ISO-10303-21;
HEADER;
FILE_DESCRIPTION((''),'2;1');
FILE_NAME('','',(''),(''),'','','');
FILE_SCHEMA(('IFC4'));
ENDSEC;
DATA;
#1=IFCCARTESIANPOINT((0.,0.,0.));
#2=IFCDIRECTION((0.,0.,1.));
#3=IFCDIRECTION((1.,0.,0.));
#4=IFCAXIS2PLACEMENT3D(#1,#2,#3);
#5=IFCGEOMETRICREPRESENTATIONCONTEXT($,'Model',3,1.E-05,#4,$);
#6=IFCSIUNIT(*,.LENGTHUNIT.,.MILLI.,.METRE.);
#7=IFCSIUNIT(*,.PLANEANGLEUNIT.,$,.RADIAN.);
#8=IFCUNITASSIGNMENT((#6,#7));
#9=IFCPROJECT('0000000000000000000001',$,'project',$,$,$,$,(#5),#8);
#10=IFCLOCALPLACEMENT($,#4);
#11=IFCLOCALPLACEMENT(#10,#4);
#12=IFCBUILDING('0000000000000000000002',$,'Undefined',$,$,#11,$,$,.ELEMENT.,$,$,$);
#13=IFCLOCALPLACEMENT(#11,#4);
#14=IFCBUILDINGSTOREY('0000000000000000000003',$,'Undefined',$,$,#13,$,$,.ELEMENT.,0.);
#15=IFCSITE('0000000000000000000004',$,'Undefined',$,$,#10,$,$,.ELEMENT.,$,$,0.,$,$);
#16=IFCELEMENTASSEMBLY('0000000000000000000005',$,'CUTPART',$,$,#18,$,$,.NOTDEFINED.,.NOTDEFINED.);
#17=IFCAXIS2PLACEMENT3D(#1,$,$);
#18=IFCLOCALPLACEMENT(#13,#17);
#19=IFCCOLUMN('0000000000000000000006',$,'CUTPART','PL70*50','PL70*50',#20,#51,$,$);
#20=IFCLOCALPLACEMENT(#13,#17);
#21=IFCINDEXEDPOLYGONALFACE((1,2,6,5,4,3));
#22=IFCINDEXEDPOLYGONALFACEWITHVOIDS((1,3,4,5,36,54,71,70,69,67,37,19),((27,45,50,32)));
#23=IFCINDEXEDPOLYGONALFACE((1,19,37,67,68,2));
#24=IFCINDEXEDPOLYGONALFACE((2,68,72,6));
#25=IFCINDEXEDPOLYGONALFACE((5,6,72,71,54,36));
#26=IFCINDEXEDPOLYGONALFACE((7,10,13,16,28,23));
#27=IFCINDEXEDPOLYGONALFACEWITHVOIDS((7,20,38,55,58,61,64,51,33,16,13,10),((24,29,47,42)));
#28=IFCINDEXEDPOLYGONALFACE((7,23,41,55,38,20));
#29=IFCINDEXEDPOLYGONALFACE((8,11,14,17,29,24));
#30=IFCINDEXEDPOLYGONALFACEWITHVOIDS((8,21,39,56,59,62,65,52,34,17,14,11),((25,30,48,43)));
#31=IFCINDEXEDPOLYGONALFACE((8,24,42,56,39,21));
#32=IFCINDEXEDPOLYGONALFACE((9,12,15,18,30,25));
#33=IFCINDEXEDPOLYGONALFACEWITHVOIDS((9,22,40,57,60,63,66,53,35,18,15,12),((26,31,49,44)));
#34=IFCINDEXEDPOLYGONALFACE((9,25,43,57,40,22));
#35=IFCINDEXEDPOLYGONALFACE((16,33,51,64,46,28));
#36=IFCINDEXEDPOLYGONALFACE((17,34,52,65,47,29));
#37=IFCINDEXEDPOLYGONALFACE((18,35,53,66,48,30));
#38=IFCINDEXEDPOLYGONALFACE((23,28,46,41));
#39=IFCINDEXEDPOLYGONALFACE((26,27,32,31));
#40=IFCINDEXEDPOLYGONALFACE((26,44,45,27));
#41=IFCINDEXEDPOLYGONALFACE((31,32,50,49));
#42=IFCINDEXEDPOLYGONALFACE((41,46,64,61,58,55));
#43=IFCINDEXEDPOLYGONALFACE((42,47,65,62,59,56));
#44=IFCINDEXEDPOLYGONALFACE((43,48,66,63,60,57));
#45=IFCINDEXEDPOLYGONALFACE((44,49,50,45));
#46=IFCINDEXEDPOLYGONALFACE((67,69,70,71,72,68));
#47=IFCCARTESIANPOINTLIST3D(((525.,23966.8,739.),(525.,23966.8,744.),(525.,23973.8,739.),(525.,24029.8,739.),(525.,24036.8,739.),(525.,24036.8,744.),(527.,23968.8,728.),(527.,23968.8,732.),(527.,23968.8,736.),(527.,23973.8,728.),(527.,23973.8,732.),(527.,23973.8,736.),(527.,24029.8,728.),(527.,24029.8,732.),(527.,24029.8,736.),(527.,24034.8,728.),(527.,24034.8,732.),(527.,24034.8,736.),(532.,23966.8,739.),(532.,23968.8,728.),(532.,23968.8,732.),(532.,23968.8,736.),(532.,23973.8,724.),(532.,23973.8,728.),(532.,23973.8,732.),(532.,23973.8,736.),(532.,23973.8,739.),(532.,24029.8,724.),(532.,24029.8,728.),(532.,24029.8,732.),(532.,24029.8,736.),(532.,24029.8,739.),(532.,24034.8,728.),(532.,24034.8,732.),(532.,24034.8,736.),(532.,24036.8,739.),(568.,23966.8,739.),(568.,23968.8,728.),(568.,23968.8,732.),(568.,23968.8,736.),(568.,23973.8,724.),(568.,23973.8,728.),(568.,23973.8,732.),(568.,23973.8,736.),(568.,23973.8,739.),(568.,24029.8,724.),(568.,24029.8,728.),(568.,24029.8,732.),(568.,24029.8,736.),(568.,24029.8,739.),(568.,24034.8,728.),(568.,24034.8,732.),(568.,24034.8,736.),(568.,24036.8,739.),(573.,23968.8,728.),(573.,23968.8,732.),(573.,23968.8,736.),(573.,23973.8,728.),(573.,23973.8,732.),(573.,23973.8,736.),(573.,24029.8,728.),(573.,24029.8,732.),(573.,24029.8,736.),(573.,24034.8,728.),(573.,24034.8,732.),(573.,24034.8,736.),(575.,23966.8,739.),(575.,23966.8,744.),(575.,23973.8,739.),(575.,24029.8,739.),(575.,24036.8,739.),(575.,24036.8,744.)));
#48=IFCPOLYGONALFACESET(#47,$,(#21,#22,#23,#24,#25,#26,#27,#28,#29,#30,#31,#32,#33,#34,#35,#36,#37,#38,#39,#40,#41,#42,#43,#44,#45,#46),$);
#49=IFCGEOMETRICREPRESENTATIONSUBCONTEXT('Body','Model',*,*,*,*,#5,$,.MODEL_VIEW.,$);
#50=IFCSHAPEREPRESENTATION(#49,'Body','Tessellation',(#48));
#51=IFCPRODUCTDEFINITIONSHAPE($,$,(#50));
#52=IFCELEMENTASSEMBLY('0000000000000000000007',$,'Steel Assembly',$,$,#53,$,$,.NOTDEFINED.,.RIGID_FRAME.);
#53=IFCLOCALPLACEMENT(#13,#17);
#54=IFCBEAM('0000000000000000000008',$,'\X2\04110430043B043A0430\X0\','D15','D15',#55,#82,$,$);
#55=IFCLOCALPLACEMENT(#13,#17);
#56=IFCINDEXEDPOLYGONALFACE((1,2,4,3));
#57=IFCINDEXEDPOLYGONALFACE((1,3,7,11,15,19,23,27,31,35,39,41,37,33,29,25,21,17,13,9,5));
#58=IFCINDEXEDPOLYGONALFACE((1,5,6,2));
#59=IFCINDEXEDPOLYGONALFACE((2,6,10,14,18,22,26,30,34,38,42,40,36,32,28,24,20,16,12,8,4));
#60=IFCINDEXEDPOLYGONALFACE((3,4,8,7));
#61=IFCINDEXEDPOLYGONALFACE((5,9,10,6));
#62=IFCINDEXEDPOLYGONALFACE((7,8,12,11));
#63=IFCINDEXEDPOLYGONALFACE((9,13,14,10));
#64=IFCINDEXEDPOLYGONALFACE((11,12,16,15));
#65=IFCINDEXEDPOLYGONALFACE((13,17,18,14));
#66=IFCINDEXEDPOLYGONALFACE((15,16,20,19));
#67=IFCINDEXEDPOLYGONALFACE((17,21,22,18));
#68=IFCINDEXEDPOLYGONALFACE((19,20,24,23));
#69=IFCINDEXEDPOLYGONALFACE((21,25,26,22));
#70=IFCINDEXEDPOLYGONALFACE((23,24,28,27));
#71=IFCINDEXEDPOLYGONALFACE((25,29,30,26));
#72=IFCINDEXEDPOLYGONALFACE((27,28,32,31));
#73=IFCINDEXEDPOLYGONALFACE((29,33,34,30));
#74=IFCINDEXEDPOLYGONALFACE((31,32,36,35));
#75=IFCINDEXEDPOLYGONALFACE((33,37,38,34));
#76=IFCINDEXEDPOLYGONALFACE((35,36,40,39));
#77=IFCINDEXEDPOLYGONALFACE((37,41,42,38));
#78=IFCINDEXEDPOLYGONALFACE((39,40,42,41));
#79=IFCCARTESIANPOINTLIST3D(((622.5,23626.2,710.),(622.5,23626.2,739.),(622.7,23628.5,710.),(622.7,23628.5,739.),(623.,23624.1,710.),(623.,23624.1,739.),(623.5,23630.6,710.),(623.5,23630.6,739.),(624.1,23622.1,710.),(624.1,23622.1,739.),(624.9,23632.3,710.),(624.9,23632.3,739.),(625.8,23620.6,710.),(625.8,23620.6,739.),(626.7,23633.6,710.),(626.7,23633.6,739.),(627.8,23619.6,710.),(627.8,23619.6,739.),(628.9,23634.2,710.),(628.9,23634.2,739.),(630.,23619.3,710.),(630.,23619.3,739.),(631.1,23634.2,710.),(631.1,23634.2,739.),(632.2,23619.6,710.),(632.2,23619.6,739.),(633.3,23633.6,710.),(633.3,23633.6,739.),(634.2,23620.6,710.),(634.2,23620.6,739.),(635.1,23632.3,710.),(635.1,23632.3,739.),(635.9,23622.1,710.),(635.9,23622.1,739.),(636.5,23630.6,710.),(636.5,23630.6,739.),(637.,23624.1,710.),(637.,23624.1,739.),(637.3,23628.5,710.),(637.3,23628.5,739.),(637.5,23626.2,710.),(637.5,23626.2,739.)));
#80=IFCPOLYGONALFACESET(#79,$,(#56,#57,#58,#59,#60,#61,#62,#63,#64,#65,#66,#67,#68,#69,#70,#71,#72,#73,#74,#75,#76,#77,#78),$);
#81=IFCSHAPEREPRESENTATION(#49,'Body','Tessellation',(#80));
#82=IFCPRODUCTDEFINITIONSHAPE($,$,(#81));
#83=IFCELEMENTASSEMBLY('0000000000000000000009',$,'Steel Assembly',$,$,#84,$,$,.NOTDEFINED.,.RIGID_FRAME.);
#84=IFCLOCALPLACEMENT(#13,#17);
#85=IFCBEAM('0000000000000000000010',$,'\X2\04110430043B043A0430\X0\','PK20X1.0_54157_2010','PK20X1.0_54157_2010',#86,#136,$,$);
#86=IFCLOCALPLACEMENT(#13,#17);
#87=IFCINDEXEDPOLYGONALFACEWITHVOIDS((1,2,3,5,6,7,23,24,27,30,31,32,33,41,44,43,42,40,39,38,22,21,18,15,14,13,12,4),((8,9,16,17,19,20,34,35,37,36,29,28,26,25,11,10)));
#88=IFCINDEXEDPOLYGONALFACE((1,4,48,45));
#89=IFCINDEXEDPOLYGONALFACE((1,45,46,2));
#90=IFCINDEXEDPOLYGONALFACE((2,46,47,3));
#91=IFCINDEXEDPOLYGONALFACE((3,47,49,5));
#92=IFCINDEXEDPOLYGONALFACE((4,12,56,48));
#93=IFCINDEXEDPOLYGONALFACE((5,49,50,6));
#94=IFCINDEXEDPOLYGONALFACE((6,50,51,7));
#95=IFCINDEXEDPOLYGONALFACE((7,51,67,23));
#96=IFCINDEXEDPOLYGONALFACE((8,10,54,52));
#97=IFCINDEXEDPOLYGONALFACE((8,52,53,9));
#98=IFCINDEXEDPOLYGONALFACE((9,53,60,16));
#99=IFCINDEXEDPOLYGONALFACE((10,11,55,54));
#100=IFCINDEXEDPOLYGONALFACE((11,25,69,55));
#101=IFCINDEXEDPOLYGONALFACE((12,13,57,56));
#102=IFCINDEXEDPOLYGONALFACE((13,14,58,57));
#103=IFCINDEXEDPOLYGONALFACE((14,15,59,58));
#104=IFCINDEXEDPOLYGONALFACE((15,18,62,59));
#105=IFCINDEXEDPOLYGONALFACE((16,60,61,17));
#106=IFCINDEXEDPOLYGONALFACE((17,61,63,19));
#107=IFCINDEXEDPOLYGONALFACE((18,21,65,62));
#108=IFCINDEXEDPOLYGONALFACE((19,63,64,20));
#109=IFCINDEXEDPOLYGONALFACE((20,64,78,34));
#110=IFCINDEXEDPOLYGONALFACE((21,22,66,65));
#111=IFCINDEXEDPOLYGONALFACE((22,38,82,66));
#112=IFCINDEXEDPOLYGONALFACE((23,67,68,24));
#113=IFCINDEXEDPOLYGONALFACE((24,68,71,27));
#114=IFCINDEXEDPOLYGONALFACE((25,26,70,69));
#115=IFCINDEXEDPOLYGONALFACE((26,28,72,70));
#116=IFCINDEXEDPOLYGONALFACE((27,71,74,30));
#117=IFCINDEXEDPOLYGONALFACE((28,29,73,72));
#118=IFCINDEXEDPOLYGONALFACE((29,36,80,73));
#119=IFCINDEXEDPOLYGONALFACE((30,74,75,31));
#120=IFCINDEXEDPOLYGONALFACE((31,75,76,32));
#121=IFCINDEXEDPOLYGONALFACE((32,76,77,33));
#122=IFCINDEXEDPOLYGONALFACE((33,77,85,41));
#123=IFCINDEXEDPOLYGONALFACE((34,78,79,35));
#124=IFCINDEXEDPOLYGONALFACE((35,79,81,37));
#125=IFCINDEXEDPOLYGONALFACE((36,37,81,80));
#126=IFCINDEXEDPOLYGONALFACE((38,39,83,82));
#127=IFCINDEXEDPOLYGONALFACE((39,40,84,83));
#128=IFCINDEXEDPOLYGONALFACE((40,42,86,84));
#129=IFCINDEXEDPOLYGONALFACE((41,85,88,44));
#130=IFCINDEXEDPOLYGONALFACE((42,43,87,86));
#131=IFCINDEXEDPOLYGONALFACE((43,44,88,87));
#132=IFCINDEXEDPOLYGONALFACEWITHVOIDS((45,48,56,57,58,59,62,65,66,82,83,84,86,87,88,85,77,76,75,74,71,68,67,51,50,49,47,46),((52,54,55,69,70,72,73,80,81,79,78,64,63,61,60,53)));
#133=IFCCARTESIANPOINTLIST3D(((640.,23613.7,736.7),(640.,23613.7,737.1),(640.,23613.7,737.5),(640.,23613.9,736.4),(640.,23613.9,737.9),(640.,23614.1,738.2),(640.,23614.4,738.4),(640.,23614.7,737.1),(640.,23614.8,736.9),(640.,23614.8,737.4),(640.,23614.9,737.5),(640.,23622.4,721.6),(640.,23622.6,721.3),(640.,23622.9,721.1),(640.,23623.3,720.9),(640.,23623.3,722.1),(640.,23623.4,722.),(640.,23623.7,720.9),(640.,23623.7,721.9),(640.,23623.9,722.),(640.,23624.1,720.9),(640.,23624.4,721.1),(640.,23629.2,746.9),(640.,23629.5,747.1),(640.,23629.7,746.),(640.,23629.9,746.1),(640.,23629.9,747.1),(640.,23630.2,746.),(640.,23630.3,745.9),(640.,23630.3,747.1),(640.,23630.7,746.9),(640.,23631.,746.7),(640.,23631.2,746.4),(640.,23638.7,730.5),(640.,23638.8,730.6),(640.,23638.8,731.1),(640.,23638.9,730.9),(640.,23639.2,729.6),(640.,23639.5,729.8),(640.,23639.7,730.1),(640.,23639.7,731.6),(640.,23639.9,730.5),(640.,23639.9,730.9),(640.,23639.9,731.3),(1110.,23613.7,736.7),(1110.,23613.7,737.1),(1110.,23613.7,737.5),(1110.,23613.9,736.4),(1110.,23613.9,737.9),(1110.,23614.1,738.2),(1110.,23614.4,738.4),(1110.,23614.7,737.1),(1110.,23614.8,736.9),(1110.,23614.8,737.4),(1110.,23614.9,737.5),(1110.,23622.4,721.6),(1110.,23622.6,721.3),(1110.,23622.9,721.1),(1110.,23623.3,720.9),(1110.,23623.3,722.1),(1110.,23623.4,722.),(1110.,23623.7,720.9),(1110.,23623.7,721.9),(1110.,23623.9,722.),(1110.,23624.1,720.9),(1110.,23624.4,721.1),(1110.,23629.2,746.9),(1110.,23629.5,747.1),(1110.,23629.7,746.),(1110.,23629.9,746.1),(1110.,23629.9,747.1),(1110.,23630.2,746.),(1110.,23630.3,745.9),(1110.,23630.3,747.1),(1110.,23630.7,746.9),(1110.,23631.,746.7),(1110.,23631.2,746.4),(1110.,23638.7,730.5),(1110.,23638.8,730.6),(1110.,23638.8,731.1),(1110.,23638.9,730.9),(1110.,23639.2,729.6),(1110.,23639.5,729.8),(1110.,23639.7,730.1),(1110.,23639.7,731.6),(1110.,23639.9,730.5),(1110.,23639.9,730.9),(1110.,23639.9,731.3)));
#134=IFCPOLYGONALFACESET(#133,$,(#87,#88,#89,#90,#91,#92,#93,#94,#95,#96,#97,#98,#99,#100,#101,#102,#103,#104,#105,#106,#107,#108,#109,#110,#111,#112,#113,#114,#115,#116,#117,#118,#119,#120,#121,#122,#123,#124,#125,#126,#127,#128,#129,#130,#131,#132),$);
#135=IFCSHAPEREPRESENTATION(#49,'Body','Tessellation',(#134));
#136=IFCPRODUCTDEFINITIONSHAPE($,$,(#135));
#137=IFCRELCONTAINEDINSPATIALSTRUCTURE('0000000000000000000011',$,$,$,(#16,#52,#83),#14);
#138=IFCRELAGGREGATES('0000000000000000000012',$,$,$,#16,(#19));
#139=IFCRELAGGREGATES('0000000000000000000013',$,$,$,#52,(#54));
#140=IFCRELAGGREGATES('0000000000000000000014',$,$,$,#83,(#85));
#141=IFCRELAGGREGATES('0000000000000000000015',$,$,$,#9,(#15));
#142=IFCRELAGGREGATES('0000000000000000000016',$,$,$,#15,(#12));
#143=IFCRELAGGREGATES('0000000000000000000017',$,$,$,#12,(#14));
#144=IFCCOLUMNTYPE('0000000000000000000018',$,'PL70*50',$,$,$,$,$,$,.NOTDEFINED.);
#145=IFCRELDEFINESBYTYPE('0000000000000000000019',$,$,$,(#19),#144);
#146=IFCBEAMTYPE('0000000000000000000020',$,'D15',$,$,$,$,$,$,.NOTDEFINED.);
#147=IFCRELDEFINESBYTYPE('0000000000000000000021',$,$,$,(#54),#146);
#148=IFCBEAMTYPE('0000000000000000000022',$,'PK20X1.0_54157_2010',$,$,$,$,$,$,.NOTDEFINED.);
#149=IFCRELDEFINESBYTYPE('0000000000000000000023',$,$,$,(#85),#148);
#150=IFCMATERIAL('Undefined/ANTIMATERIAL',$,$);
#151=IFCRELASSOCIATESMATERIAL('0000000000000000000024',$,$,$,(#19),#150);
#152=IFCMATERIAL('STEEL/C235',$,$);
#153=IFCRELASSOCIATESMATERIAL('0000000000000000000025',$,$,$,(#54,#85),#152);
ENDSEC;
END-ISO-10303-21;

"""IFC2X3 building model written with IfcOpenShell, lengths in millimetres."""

from ifc_helpers import new_model, si_unit, frame, origin_with_axes, origin_2d_with_axis, place, context, subcontext, project, spatial, polyline, rectangle, hollow_rectangle, circle, outline, extrude, boolean, material, type_object, element, aggregate, save


model = new_model("IFC2X3")

# Units and contexts
model_context = context("Model", 3, precision=1e-05, world=origin_with_axes())
body_context = subcontext(model_context, "Body", "Model", "MODEL_VIEW")
ifc_project = project(units=[si_unit("LENGTHUNIT", "METRE", prefix="MILLI"), si_unit("PLANEANGLEUNIT", "RADIAN")], contexts=[model_context])

# Site, building, storey
site_placement = place(None, origin_with_axes())
site = spatial("IfcSite", under=ifc_project, at=site_placement, Name="Undefined", CompositionType="ELEMENT", RefElevation=0.0)
building_placement = place(site_placement, origin_with_axes())
building = spatial("IfcBuilding", under=site, at=building_placement, Name="Undefined", CompositionType="ELEMENT")
storey_placement = place(building_placement, origin_with_axes())
storey = spatial("IfcBuildingStorey", under=building, at=storey_placement, Name="Undefined", CompositionType="ELEMENT", Elevation=0.0)

# Element assembly, column
assembly_1_placement = place(storey_placement, origin_with_axes())
assembly_1 = element("IfcElementAssembly", 1, at=assembly_1_placement, inside=storey, Name="CUTPART", AssemblyPlace="NOTDEFINED", PredefinedType="NOTDEFINED")
ifc_material_1 = material(Name="Undefined/ANTIMATERIAL")
column_type = type_object("IfcColumnType", Name="PL70*50", PredefinedType="NOTDEFINED")
column_placement = place(assembly_1_placement, frame((550.0, 24001.8, 724.0), z_axis=(0.0, 0.0, 1.0), x_axis=(0.0, -1.0, 0.0)))
column = element("IfcColumn", 2, at=column_placement, type_object=column_type, material=ifc_material_1, Name="CUTPART", Description="PL70*50", ObjectType="PL70*50", context=body_context, shape_type="CSG", body=[
    boolean("DIFFERENCE", boolean("DIFFERENCE", boolean("DIFFERENCE", boolean("DIFFERENCE", extrude(rectangle(XDim=50.0, YDim=70.0, at=origin_2d_with_axis()), frame((0.0, 0.0, 20.0), z_axis=(0.0, 0.0, -1.0), x_axis=(0.0, 1.0, 0.0)), (0.0, 0.0, 1.0), 20.0), extrude(outline(polyline([(0.0, 0.0), (15.0, 0.0), (15.0, 7.0), (11.0, 2.0), (11.0, 7.0), (7.0, 2.0), (7.0, 7.0), (3.0, 2.0), (3.0, 7.0), (0.0, 7.0), (0.0, 0.0)])), frame((-35.0, 40.0, 15.0), z_axis=(0.0, -1.0, 0.0), x_axis=(0.0, 0.0, -1.0)), (0.0, 0.0, 1.0), 80.0)), extrude(outline(polyline([(0.0, 0.0), (15.0, 0.0), (15.0, 7.0), (11.0, 2.0), (11.0, 7.0), (7.0, 2.0), (7.0, 7.0), (3.0, 2.0), (3.0, 7.0), (0.0, 7.0), (0.0, 0.0)])), frame((35.0, -40.0, 15.0), z_axis=(0.0, 1.0, 0.0), x_axis=(0.0, 0.0, -1.0)), (0.0, 0.0, 1.0), 80.0)), extrude(outline(polyline([(0.0, 0.0), (15.0, 0.0), (15.0, 7.0), (11.0, 2.0), (11.0, 7.0), (7.0, 2.0), (7.0, 7.0), (3.0, 2.0), (3.0, 7.0), (0.0, 7.0), (0.0, 0.0)])), frame((40.0, 25.0, 15.0), z_axis=(-1.0, 0.0, 0.0), x_axis=(0.0, 0.0, -1.0)), (0.0, 0.0, 1.0), 80.0)), extrude(outline(polyline([(0.0, 0.0), (15.0, 0.0), (15.0, 7.0), (11.0, 2.0), (11.0, 7.0), (7.0, 2.0), (7.0, 7.0), (3.0, 2.0), (3.0, 7.0), (0.0, 7.0), (0.0, 0.0)])), frame((-40.0, -25.0, 15.0), z_axis=(1.0, 0.0, 0.0), x_axis=(0.0, 0.0, -1.0)), (0.0, 0.0, 1.0), 80.0)),
])
aggregate(assembly_1, [column])

# Element assemblies, beams
assembly_2_placement = place(storey_placement, origin_with_axes())
assembly_2 = element("IfcElementAssembly", 3, at=assembly_2_placement, inside=storey, Name="Steel Assembly", AssemblyPlace="NOTDEFINED", PredefinedType="RIGID_FRAME")
ifc_material_2 = material(Name="STEEL/C235")
beam_type_1 = type_object("IfcBeamType", Name="D15", PredefinedType="NOTDEFINED")
beam_1_placement = place(assembly_2_placement, frame((630.0, 23626.8, 739.0), z_axis=(1.0, 0.0, 0.0), x_axis=(0.0, 0.0, -1.0)))
beam_1 = element("IfcBeam", 4, at=beam_1_placement, type_object=beam_type_1, material=ifc_material_2, Name="Балка", Description="D15", ObjectType="D15", context=body_context, shape_type="SweptSolid", body=[
    extrude(circle(Radius=7.5, at=origin_2d_with_axis()), frame((29.0, 0.0, 0.0), z_axis=(-1.0, 0.0, 0.0), x_axis=(0.0, -1.0, 0.0)), (0.0, 0.0, 1.0), 29.0),
])
aggregate(assembly_2, [beam_1])
assembly_3_placement = place(storey_placement, origin_with_axes())
assembly_3 = element("IfcElementAssembly", 5, at=assembly_3_placement, inside=storey, Name="Steel Assembly", AssemblyPlace="NOTDEFINED", PredefinedType="RIGID_FRAME")
beam_type_2 = type_object("IfcBeamType", Name="PK20X1.0_54157_2010", PredefinedType="NOTDEFINED")
beam_2_placement = place(assembly_3_placement, frame((640.0, 23626.8, 734.0), z_axis=(0.0, -0.866025, -0.5), x_axis=(1.0, 0.0, 0.0)))
beam_2 = element("IfcBeam", 6, at=beam_2_placement, type_object=beam_type_2, material=ifc_material_2, Name="Балка", Description="PK20X1.0_54157_2010", ObjectType="PK20X1.0_54157_2010", context=body_context, shape_type="SweptSolid", body=[
    extrude(hollow_rectangle(XDim=20.0, YDim=20.0, WallThickness=1.0, InnerFilletRadius=0.5, OuterFilletRadius=1.5, at=origin_2d_with_axis()), frame((470.0, 0.0, 0.0), z_axis=(-1.0, 0.0, 0.0), x_axis=(0.0, -1.0, 0.0)), (0.0, 0.0, 1.0), 470.0),
])
aggregate(assembly_3, [beam_2])

save(model, "model.ifc")
